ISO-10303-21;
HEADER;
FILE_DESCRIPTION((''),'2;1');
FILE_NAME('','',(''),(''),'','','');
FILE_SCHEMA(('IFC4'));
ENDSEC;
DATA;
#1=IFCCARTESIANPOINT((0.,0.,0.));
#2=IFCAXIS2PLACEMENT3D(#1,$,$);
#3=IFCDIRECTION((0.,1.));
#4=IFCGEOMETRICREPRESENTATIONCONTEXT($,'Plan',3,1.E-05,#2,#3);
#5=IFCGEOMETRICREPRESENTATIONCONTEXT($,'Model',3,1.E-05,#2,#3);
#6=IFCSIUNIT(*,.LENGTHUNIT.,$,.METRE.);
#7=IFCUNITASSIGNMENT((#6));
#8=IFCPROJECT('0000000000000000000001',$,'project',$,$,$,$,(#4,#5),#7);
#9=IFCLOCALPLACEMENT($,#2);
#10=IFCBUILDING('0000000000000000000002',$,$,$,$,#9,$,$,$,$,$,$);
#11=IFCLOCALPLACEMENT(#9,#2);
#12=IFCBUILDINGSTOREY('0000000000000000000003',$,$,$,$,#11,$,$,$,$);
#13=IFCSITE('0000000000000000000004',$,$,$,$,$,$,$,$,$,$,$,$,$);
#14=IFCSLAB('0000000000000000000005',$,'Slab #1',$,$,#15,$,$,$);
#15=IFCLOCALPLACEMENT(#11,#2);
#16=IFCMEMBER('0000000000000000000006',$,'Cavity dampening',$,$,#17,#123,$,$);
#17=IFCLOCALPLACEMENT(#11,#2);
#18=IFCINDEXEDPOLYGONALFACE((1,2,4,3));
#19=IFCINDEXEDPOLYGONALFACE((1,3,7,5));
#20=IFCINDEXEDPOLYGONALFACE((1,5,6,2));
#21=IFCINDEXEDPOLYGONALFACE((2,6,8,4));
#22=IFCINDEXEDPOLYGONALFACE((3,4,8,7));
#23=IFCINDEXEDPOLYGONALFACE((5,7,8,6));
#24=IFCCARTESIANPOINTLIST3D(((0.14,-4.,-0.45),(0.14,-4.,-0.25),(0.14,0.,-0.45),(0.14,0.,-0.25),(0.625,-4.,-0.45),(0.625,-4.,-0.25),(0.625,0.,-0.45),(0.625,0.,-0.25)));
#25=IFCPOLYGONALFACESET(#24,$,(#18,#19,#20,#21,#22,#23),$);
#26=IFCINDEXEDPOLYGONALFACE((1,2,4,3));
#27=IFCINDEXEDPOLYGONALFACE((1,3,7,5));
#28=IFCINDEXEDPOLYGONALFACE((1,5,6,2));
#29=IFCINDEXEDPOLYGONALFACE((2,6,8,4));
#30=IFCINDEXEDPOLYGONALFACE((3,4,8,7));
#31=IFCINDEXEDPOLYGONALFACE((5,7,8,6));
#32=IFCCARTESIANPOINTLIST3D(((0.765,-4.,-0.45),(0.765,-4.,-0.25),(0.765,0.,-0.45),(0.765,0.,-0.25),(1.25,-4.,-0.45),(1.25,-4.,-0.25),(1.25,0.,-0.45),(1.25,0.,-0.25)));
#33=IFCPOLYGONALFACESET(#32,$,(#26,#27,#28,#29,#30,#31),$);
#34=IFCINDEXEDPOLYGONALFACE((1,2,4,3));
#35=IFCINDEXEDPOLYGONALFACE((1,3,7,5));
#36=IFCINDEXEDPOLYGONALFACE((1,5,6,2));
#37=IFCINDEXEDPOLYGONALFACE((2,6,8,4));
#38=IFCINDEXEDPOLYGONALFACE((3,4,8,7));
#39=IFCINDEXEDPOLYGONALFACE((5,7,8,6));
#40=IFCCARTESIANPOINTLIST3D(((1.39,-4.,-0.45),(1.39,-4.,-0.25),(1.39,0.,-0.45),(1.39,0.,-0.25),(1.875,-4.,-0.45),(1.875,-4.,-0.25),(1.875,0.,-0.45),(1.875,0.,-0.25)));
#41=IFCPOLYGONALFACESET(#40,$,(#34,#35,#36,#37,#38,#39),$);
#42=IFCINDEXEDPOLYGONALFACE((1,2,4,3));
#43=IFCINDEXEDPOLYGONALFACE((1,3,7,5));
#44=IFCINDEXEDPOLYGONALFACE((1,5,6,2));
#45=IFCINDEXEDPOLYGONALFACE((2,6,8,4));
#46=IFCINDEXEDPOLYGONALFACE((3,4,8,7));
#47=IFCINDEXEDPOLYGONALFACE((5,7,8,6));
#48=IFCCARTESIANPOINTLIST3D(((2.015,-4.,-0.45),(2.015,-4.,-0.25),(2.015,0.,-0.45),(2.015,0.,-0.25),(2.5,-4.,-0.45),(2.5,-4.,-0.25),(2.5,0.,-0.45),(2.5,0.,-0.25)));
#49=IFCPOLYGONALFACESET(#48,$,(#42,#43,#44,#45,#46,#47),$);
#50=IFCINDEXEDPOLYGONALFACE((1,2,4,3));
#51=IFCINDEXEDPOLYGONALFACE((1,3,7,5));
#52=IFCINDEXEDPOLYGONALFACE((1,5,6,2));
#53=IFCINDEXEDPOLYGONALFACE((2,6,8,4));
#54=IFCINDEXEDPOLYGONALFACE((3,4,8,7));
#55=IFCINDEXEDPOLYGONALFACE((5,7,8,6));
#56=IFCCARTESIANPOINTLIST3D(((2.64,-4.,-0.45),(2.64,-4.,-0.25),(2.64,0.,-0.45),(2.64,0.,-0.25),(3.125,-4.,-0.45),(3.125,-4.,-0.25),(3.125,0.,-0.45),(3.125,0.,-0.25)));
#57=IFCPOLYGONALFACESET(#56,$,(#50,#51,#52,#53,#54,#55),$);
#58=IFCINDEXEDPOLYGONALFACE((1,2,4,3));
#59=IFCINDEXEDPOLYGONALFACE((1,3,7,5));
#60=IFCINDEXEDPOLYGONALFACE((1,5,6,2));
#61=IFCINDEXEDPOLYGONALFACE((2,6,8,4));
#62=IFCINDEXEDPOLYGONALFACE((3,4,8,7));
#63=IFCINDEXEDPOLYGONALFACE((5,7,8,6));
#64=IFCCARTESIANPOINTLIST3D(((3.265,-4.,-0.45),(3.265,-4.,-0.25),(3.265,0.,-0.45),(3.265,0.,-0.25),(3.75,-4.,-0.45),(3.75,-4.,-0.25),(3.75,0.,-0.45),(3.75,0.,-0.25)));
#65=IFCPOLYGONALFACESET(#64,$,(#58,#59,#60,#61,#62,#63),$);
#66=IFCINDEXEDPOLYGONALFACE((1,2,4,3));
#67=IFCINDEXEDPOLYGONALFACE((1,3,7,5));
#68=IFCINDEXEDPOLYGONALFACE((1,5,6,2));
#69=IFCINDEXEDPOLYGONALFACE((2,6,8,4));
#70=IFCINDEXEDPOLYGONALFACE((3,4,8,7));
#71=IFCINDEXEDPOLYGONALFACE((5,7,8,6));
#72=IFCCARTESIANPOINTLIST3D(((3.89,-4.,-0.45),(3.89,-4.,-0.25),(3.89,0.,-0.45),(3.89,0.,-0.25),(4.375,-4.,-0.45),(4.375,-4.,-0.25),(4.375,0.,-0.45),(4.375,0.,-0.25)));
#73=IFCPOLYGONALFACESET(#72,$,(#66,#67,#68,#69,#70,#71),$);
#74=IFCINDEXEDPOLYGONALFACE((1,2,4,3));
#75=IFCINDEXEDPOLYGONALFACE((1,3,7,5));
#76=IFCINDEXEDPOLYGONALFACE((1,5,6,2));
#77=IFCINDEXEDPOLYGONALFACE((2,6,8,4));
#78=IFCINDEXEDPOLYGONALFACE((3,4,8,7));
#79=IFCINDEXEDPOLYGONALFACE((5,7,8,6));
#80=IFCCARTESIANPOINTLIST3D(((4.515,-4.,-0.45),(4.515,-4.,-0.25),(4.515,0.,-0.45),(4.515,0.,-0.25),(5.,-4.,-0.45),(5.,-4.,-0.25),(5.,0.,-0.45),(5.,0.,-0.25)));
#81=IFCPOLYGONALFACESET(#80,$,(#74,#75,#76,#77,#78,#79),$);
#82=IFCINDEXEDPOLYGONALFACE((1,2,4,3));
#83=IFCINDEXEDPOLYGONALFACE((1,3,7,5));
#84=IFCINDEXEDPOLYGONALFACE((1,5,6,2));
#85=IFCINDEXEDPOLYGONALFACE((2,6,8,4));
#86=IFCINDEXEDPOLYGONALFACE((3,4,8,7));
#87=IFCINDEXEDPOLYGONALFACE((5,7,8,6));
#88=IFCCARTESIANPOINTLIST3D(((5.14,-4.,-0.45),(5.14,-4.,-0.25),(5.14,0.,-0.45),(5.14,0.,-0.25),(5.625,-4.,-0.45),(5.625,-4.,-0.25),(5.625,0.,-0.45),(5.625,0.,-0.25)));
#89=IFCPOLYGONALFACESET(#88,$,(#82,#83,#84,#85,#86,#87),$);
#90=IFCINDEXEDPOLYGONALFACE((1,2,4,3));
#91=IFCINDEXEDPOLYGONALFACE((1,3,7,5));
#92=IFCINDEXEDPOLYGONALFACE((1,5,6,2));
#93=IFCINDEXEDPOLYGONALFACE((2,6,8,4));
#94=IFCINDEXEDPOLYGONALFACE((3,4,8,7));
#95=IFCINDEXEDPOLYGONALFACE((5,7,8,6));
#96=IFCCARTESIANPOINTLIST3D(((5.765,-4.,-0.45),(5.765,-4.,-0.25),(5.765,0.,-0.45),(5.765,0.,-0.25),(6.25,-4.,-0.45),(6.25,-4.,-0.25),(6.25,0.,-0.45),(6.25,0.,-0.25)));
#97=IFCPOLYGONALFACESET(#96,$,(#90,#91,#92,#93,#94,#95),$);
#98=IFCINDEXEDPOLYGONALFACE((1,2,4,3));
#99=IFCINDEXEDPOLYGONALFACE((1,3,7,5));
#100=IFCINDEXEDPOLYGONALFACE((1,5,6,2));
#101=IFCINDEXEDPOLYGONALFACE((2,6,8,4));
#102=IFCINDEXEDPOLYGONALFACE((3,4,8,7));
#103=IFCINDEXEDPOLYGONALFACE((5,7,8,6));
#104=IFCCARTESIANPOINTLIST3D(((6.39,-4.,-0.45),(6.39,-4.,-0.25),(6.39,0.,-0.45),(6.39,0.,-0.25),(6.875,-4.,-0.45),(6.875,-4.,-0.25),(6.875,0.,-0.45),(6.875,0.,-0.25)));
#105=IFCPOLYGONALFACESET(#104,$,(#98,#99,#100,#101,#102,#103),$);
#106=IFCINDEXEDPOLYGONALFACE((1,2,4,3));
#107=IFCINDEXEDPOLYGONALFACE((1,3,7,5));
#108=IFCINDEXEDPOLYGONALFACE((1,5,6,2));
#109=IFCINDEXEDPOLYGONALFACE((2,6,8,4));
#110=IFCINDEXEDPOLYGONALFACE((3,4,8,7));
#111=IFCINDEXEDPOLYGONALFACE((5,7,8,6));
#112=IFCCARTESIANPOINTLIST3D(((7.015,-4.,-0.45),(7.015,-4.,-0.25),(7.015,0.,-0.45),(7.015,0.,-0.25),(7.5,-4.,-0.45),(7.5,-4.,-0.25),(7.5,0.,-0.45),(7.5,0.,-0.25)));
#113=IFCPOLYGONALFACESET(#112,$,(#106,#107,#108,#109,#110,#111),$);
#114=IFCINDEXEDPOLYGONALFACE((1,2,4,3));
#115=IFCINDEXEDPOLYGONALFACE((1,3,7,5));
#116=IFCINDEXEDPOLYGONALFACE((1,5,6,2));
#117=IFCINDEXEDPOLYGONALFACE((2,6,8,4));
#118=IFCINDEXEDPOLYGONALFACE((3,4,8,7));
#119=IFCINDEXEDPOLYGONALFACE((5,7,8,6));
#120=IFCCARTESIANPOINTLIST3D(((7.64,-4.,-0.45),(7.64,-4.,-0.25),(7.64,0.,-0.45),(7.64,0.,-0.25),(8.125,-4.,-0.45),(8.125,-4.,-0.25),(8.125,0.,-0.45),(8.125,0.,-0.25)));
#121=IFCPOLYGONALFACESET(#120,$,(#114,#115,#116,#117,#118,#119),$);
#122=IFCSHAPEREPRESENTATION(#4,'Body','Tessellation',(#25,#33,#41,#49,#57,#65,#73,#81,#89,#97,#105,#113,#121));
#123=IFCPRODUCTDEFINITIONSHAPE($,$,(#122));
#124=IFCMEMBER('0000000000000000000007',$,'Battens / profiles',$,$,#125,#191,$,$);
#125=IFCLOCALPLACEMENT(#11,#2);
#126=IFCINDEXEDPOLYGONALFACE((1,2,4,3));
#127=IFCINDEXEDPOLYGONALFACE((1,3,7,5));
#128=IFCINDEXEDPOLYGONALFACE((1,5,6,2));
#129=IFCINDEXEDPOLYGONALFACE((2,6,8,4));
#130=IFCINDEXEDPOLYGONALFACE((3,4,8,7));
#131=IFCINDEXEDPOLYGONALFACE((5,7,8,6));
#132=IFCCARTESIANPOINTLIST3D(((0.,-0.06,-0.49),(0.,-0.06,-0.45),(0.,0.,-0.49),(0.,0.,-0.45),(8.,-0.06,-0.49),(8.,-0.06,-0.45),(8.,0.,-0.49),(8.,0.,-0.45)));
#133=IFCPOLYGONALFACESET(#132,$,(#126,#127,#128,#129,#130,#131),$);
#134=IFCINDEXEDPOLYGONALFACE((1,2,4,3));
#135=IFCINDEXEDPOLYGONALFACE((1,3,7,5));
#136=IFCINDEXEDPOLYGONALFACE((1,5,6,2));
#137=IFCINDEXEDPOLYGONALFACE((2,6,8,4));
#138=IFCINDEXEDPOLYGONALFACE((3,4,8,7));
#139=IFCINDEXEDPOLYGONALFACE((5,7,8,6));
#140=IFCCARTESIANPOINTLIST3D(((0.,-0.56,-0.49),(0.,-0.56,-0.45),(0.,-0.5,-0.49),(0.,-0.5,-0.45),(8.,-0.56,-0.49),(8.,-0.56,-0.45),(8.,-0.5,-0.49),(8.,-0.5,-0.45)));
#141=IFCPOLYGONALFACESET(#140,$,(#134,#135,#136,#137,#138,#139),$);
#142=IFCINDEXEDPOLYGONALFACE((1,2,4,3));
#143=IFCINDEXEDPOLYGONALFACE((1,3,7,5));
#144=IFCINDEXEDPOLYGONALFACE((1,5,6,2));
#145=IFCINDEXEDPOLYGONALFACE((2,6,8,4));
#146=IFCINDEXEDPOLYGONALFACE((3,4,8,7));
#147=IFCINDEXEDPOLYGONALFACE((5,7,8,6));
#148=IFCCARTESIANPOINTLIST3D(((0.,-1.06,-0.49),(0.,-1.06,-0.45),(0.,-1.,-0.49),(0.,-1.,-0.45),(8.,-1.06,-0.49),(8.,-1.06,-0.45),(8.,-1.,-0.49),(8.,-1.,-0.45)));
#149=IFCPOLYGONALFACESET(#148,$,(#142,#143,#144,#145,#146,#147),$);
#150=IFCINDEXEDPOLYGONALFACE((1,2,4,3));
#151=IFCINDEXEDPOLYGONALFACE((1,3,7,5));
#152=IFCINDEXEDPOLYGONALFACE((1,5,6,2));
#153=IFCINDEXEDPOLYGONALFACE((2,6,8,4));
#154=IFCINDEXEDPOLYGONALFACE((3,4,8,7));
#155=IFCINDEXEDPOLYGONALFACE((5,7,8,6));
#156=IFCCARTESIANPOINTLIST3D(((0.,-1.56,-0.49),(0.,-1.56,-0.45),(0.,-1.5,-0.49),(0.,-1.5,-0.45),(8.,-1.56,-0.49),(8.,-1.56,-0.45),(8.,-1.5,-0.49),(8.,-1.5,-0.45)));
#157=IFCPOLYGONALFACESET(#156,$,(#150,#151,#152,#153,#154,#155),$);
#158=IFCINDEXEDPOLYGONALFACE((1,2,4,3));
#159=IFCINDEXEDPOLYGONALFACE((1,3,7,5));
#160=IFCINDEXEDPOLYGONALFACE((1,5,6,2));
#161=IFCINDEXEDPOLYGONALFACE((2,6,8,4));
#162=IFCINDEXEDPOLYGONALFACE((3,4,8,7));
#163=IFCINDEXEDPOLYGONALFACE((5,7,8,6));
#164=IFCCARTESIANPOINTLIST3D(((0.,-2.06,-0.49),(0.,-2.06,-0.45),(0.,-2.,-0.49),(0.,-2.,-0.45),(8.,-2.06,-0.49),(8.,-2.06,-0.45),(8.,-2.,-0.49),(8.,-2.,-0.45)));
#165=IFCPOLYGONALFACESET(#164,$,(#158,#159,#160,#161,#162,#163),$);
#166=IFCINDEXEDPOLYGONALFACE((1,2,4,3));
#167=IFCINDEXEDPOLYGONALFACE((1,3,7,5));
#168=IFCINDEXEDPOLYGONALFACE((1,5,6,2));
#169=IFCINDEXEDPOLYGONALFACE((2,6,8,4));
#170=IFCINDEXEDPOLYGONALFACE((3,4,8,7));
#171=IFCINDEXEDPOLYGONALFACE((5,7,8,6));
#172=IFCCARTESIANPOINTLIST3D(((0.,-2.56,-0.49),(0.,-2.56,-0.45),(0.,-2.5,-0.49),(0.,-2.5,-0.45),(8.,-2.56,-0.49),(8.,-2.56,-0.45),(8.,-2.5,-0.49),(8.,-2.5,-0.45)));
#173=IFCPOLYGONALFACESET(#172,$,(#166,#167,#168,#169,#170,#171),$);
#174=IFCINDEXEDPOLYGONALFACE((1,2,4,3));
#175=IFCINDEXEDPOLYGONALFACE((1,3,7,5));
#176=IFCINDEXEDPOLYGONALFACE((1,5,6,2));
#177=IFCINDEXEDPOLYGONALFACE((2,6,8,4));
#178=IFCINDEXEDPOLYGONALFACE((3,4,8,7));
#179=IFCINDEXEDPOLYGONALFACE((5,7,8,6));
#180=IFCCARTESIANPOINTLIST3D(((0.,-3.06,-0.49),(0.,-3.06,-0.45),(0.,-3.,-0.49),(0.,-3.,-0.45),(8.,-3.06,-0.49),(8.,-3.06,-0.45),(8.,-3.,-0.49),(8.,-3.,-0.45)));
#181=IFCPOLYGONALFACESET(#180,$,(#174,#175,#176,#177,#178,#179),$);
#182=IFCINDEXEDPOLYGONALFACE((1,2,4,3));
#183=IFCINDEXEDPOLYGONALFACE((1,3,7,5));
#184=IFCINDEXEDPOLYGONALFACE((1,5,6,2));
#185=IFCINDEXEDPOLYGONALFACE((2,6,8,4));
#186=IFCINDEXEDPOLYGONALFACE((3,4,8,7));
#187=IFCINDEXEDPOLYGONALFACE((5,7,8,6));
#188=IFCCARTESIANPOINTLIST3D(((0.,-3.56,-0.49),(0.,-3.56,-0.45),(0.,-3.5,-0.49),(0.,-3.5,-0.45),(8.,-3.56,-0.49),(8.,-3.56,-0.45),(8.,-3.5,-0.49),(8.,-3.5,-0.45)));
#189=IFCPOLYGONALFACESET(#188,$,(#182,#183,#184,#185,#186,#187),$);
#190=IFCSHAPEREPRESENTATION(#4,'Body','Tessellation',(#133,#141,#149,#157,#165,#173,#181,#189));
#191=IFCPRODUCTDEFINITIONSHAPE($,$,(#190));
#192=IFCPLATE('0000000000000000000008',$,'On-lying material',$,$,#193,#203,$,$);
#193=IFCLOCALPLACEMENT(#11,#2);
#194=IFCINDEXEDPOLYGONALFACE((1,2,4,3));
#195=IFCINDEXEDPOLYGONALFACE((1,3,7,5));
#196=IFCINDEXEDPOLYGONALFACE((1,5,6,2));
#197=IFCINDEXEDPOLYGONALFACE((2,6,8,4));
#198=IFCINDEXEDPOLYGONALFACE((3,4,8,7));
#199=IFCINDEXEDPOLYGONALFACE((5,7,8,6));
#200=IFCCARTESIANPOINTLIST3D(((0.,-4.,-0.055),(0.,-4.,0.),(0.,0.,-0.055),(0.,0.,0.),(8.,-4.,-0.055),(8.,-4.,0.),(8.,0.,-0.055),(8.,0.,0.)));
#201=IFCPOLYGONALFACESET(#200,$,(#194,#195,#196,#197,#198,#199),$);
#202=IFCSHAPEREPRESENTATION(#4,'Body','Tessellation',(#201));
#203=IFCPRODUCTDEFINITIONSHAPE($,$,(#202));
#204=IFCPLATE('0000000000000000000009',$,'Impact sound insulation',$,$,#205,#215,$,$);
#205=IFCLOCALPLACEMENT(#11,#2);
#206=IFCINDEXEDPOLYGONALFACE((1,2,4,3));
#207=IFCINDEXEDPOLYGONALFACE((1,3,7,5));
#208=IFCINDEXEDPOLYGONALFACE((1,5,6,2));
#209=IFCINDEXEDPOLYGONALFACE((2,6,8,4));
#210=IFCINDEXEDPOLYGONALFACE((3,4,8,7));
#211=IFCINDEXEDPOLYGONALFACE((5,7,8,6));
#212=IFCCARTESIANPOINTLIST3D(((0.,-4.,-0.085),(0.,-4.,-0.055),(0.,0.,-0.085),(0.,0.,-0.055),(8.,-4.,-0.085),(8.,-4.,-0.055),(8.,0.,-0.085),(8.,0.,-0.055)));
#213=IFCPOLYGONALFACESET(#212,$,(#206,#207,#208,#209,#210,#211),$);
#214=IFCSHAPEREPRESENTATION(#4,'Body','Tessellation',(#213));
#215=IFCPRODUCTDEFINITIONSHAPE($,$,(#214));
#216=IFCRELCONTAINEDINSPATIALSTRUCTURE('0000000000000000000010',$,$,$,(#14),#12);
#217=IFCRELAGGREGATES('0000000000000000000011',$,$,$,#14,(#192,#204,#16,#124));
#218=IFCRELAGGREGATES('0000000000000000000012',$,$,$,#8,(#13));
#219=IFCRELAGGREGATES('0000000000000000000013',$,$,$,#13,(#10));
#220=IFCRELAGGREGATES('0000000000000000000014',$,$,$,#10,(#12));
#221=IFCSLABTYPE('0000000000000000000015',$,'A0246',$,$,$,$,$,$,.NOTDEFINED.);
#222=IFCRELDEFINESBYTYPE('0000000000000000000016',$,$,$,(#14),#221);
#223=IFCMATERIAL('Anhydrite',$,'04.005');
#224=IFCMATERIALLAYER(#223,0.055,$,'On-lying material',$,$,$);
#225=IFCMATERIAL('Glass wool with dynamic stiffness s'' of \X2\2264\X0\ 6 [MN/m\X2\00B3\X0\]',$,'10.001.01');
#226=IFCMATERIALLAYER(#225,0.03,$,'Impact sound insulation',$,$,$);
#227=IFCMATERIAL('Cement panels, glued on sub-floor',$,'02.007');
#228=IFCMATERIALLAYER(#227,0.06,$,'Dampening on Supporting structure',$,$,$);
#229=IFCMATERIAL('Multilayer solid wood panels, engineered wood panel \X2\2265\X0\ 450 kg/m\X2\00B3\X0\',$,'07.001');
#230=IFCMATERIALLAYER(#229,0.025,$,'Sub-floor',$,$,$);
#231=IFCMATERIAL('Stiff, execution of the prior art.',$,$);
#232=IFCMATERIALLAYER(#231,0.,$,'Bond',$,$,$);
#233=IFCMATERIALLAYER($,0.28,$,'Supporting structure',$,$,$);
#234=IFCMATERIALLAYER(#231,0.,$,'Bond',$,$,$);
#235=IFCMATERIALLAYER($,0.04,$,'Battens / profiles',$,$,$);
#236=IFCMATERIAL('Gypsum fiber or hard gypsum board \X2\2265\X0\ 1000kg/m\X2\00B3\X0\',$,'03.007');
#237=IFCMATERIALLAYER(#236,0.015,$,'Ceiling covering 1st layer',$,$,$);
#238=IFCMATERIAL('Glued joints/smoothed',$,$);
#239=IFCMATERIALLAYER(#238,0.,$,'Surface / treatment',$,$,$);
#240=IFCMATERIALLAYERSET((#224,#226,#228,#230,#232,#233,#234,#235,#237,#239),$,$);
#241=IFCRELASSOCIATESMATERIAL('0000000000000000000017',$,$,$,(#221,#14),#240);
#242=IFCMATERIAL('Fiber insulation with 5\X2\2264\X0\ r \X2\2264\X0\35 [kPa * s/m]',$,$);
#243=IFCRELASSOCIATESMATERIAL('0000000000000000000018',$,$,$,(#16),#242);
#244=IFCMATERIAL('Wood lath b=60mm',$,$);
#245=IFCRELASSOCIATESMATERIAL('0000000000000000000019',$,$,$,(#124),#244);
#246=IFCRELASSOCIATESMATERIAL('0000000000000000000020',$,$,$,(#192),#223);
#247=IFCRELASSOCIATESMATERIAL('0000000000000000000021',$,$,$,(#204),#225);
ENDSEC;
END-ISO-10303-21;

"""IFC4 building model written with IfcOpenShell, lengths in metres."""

from ifc_helpers import new_model, si_unit, direction, frame, frame_2d, origin, origin_with_axes, place, context, project, spatial, rectangle, extrude, material, layer, layer_set, type_object, element, aggregate, save


model = new_model("IFC4")

# Units and contexts
plan_context = context("Plan", 3, precision=1e-05, world=origin(), true_north=direction((0.0, 1.0)))
model_context = context("Model", 3, precision=1e-05, world=origin(), true_north=direction((0.0, 1.0)))
ifc_project = project(units=[si_unit("LENGTHUNIT", "METRE")], contexts=[plan_context, model_context])

# Site, building, storey
site = spatial("IfcSite", under=ifc_project)
building_placement = place(None, origin())
building = spatial("IfcBuilding", under=site, at=building_placement)
storey_placement = place(building_placement, origin())
storey = spatial("IfcBuildingStorey", under=building, at=storey_placement)

# Slab, members, plates
ifc_material_1 = material(Name="Anhydrite", Category="04.005")
ifc_layer_1 = layer(ifc_material_1, 0.055, Name="On-lying material")
ifc_material_2 = material(Name="Glass wool with dynamic stiffness s' of ≤ 6 [MN/m³]", Category="10.001.01")
ifc_layer_2 = layer(ifc_material_2, 0.03, Name="Impact sound insulation")
ifc_material_3 = material(Name="Cement panels, glued on sub-floor", Category="02.007")
ifc_layer_3 = layer(ifc_material_3, 0.06, Name="Dampening on Supporting structure")
ifc_material_4 = material(Name="Multilayer solid wood panels, engineered wood panel ≥ 450 kg/m³", Category="07.001")
ifc_layer_4 = layer(ifc_material_4, 0.025, Name="Sub-floor")
ifc_material_5 = material(Name="Stiff, execution of the prior art.")
ifc_layer_5 = layer(ifc_material_5, 0.0, Name="Bond")
ifc_layer_6 = layer(None, 0.28, Name="Supporting structure")
ifc_layer_7 = layer(ifc_material_5, 0.0, Name="Bond")
ifc_layer_8 = layer(None, 0.04, Name="Battens / profiles")
ifc_material_6 = material(Name="Gypsum fiber or hard gypsum board ≥ 1000kg/m³", Category="03.007")
ifc_layer_9 = layer(ifc_material_6, 0.015, Name="Ceiling covering 1st layer")
ifc_material_7 = material(Name="Glued joints/smoothed")
ifc_layer_10 = layer(ifc_material_7, 0.0, Name="Surface / treatment")
ifc_layer_set = layer_set([ifc_layer_1, ifc_layer_2, ifc_layer_3, ifc_layer_4, ifc_layer_5, ifc_layer_6, ifc_layer_7, ifc_layer_8, ifc_layer_9, ifc_layer_10])
slab_type = type_object("IfcSlabType", Name="A0246", PredefinedType="NOTDEFINED", material=ifc_layer_set)
slab_placement = place(None, frame((0.0, 0.0, 0.0), z_axis=(0.0, 0.0, -1.0), x_axis=(1.0, 0.0, 0.0)))
slab = element("IfcSlab", 1, at=slab_placement, inside=storey, type_object=slab_type, material=ifc_layer_set, Name="Slab #1")
ifc_material_8 = material(Name="Fiber insulation with 5≤ r ≤35 [kPa * s/m]")
member_1_placement = place(slab_placement, origin())
member_1 = element("IfcMember", 2, at=member_1_placement, material=ifc_material_8, Name="Cavity dampening", context=plan_context, shape_type="SweptSolid", body=[
    extrude(rectangle(XDim=0.485, YDim=0.2, at=frame_2d((0.2425, 0.1), x_axis=(1.0, 0.0))), frame((0.14, 4.0, 0.25), z_axis=(0.0, -1.0, 0.0), x_axis=(1.0, 0.0, 0.0)), (0.0, 0.0, 1.0), 4.0),
    extrude(rectangle(XDim=0.485, YDim=0.2, at=frame_2d((0.2425, 0.1), x_axis=(1.0, 0.0))), frame((0.765, 4.0, 0.25), z_axis=(0.0, -1.0, 0.0), x_axis=(1.0, 0.0, 0.0)), (0.0, 0.0, 1.0), 4.0),
    extrude(rectangle(XDim=0.485, YDim=0.2, at=frame_2d((0.2425, 0.1), x_axis=(1.0, 0.0))), frame((1.39, 4.0, 0.25), z_axis=(0.0, -1.0, 0.0), x_axis=(1.0, 0.0, 0.0)), (0.0, 0.0, 1.0), 4.0),
    extrude(rectangle(XDim=0.485, YDim=0.2, at=frame_2d((0.2425, 0.1), x_axis=(1.0, 0.0))), frame((2.015, 4.0, 0.25), z_axis=(0.0, -1.0, 0.0), x_axis=(1.0, 0.0, 0.0)), (0.0, 0.0, 1.0), 4.0),
    extrude(rectangle(XDim=0.485, YDim=0.2, at=frame_2d((0.2425, 0.1), x_axis=(1.0, 0.0))), frame((2.64, 4.0, 0.25), z_axis=(0.0, -1.0, 0.0), x_axis=(1.0, 0.0, 0.0)), (0.0, 0.0, 1.0), 4.0),
    extrude(rectangle(XDim=0.485, YDim=0.2, at=frame_2d((0.2425, 0.1), x_axis=(1.0, 0.0))), frame((3.265, 4.0, 0.25), z_axis=(0.0, -1.0, 0.0), x_axis=(1.0, 0.0, 0.0)), (0.0, 0.0, 1.0), 4.0),
    extrude(rectangle(XDim=0.485, YDim=0.2, at=frame_2d((0.2425, 0.1), x_axis=(1.0, 0.0))), frame((3.89, 4.0, 0.25), z_axis=(0.0, -1.0, 0.0), x_axis=(1.0, 0.0, 0.0)), (0.0, 0.0, 1.0), 4.0),
    extrude(rectangle(XDim=0.485, YDim=0.2, at=frame_2d((0.2425, 0.1), x_axis=(1.0, 0.0))), frame((4.515, 4.0, 0.25), z_axis=(0.0, -1.0, 0.0), x_axis=(1.0, 0.0, 0.0)), (0.0, 0.0, 1.0), 4.0),
    extrude(rectangle(XDim=0.485, YDim=0.2, at=frame_2d((0.2425, 0.1), x_axis=(1.0, 0.0))), frame((5.14, 4.0, 0.25), z_axis=(0.0, -1.0, 0.0), x_axis=(1.0, 0.0, 0.0)), (0.0, 0.0, 1.0), 4.0),
    extrude(rectangle(XDim=0.485, YDim=0.2, at=frame_2d((0.2425, 0.1), x_axis=(1.0, 0.0))), frame((5.765, 4.0, 0.25), z_axis=(0.0, -1.0, 0.0), x_axis=(1.0, 0.0, 0.0)), (0.0, 0.0, 1.0), 4.0),
    extrude(rectangle(XDim=0.485, YDim=0.2, at=frame_2d((0.2425, 0.1), x_axis=(1.0, 0.0))), frame((6.39, 4.0, 0.25), z_axis=(0.0, -1.0, 0.0), x_axis=(1.0, 0.0, 0.0)), (0.0, 0.0, 1.0), 4.0),
    extrude(rectangle(XDim=0.485, YDim=0.2, at=frame_2d((0.2425, 0.1), x_axis=(1.0, 0.0))), frame((7.015, 4.0, 0.25), z_axis=(0.0, -1.0, 0.0), x_axis=(1.0, 0.0, 0.0)), (0.0, 0.0, 1.0), 4.0),
    extrude(rectangle(XDim=0.485, YDim=0.2, at=frame_2d((0.2425, 0.1), x_axis=(1.0, 0.0))), frame((7.64, 4.0, 0.25), z_axis=(0.0, -1.0, 0.0), x_axis=(1.0, 0.0, 0.0)), (0.0, 0.0, 1.0), 4.0),
])
ifc_material_9 = material(Name="Wood lath b=60mm")
member_2_placement = place(slab_placement, origin())
member_2 = element("IfcMember", 3, at=member_2_placement, material=ifc_material_9, Name="Battens / profiles", context=plan_context, shape_type="SweptSolid", body=[
    extrude(rectangle(XDim=0.06, YDim=0.04, at=frame_2d((0.03, 0.02), x_axis=(1.0, 0.0))), frame((0.0, 0.0, 0.45), z_axis=(1.0, 0.0, 0.0), x_axis=(0.0, 1.0, 0.0)), (0.0, 0.0, 1.0), 8.0),
    extrude(rectangle(XDim=0.06, YDim=0.04, at=frame_2d((0.03, 0.02), x_axis=(1.0, 0.0))), frame((0.0, 0.5, 0.45), z_axis=(1.0, 0.0, 0.0), x_axis=(0.0, 1.0, 0.0)), (0.0, 0.0, 1.0), 8.0),
    extrude(rectangle(XDim=0.06, YDim=0.04, at=frame_2d((0.03, 0.02), x_axis=(1.0, 0.0))), frame((0.0, 1.0, 0.45), z_axis=(1.0, 0.0, 0.0), x_axis=(0.0, 1.0, 0.0)), (0.0, 0.0, 1.0), 8.0),
    extrude(rectangle(XDim=0.06, YDim=0.04, at=frame_2d((0.03, 0.02), x_axis=(1.0, 0.0))), frame((0.0, 1.5, 0.45), z_axis=(1.0, 0.0, 0.0), x_axis=(0.0, 1.0, 0.0)), (0.0, 0.0, 1.0), 8.0),
    extrude(rectangle(XDim=0.06, YDim=0.04, at=frame_2d((0.03, 0.02), x_axis=(1.0, 0.0))), frame((0.0, 2.0, 0.45), z_axis=(1.0, 0.0, 0.0), x_axis=(0.0, 1.0, 0.0)), (0.0, 0.0, 1.0), 8.0),
    extrude(rectangle(XDim=0.06, YDim=0.04, at=frame_2d((0.03, 0.02), x_axis=(1.0, 0.0))), frame((0.0, 2.5, 0.45), z_axis=(1.0, 0.0, 0.0), x_axis=(0.0, 1.0, 0.0)), (0.0, 0.0, 1.0), 8.0),
    extrude(rectangle(XDim=0.06, YDim=0.04, at=frame_2d((0.03, 0.02), x_axis=(1.0, 0.0))), frame((0.0, 3.0, 0.45), z_axis=(1.0, 0.0, 0.0), x_axis=(0.0, 1.0, 0.0)), (0.0, 0.0, 1.0), 8.0),
    extrude(rectangle(XDim=0.06, YDim=0.04, at=frame_2d((0.03, 0.02), x_axis=(1.0, 0.0))), frame((0.0, 3.5, 0.45), z_axis=(1.0, 0.0, 0.0), x_axis=(0.0, 1.0, 0.0)), (0.0, 0.0, 1.0), 8.0),
])
plate_1_placement = place(slab_placement, origin())
plate_1 = element("IfcPlate", 4, at=plate_1_placement, material=ifc_material_1, Name="On-lying material", context=plan_context, shape_type="SweptSolid", body=[
    extrude(rectangle(XDim=8.0, YDim=4.0, at=frame_2d((4.0, 2.0), x_axis=(1.0, 0.0))), origin_with_axes(), (0.0, 0.0, 1.0), 0.055),
])
plate_2_placement = place(slab_placement, origin())
plate_2 = element("IfcPlate", 5, at=plate_2_placement, material=ifc_material_2, Name="Impact sound insulation", context=plan_context, shape_type="SweptSolid", body=[
    extrude(rectangle(XDim=8.0, YDim=4.0, at=frame_2d((4.0, 2.0), x_axis=(1.0, 0.0))), frame((0.0, 0.0, 0.055), z_axis=(0.0, 0.0, 1.0), x_axis=(1.0, 0.0, 0.0)), (0.0, 0.0, 1.0), 0.03),
])
aggregate(slab, [plate_1, plate_2, member_1, member_2])

save(model, "model.ifc")
